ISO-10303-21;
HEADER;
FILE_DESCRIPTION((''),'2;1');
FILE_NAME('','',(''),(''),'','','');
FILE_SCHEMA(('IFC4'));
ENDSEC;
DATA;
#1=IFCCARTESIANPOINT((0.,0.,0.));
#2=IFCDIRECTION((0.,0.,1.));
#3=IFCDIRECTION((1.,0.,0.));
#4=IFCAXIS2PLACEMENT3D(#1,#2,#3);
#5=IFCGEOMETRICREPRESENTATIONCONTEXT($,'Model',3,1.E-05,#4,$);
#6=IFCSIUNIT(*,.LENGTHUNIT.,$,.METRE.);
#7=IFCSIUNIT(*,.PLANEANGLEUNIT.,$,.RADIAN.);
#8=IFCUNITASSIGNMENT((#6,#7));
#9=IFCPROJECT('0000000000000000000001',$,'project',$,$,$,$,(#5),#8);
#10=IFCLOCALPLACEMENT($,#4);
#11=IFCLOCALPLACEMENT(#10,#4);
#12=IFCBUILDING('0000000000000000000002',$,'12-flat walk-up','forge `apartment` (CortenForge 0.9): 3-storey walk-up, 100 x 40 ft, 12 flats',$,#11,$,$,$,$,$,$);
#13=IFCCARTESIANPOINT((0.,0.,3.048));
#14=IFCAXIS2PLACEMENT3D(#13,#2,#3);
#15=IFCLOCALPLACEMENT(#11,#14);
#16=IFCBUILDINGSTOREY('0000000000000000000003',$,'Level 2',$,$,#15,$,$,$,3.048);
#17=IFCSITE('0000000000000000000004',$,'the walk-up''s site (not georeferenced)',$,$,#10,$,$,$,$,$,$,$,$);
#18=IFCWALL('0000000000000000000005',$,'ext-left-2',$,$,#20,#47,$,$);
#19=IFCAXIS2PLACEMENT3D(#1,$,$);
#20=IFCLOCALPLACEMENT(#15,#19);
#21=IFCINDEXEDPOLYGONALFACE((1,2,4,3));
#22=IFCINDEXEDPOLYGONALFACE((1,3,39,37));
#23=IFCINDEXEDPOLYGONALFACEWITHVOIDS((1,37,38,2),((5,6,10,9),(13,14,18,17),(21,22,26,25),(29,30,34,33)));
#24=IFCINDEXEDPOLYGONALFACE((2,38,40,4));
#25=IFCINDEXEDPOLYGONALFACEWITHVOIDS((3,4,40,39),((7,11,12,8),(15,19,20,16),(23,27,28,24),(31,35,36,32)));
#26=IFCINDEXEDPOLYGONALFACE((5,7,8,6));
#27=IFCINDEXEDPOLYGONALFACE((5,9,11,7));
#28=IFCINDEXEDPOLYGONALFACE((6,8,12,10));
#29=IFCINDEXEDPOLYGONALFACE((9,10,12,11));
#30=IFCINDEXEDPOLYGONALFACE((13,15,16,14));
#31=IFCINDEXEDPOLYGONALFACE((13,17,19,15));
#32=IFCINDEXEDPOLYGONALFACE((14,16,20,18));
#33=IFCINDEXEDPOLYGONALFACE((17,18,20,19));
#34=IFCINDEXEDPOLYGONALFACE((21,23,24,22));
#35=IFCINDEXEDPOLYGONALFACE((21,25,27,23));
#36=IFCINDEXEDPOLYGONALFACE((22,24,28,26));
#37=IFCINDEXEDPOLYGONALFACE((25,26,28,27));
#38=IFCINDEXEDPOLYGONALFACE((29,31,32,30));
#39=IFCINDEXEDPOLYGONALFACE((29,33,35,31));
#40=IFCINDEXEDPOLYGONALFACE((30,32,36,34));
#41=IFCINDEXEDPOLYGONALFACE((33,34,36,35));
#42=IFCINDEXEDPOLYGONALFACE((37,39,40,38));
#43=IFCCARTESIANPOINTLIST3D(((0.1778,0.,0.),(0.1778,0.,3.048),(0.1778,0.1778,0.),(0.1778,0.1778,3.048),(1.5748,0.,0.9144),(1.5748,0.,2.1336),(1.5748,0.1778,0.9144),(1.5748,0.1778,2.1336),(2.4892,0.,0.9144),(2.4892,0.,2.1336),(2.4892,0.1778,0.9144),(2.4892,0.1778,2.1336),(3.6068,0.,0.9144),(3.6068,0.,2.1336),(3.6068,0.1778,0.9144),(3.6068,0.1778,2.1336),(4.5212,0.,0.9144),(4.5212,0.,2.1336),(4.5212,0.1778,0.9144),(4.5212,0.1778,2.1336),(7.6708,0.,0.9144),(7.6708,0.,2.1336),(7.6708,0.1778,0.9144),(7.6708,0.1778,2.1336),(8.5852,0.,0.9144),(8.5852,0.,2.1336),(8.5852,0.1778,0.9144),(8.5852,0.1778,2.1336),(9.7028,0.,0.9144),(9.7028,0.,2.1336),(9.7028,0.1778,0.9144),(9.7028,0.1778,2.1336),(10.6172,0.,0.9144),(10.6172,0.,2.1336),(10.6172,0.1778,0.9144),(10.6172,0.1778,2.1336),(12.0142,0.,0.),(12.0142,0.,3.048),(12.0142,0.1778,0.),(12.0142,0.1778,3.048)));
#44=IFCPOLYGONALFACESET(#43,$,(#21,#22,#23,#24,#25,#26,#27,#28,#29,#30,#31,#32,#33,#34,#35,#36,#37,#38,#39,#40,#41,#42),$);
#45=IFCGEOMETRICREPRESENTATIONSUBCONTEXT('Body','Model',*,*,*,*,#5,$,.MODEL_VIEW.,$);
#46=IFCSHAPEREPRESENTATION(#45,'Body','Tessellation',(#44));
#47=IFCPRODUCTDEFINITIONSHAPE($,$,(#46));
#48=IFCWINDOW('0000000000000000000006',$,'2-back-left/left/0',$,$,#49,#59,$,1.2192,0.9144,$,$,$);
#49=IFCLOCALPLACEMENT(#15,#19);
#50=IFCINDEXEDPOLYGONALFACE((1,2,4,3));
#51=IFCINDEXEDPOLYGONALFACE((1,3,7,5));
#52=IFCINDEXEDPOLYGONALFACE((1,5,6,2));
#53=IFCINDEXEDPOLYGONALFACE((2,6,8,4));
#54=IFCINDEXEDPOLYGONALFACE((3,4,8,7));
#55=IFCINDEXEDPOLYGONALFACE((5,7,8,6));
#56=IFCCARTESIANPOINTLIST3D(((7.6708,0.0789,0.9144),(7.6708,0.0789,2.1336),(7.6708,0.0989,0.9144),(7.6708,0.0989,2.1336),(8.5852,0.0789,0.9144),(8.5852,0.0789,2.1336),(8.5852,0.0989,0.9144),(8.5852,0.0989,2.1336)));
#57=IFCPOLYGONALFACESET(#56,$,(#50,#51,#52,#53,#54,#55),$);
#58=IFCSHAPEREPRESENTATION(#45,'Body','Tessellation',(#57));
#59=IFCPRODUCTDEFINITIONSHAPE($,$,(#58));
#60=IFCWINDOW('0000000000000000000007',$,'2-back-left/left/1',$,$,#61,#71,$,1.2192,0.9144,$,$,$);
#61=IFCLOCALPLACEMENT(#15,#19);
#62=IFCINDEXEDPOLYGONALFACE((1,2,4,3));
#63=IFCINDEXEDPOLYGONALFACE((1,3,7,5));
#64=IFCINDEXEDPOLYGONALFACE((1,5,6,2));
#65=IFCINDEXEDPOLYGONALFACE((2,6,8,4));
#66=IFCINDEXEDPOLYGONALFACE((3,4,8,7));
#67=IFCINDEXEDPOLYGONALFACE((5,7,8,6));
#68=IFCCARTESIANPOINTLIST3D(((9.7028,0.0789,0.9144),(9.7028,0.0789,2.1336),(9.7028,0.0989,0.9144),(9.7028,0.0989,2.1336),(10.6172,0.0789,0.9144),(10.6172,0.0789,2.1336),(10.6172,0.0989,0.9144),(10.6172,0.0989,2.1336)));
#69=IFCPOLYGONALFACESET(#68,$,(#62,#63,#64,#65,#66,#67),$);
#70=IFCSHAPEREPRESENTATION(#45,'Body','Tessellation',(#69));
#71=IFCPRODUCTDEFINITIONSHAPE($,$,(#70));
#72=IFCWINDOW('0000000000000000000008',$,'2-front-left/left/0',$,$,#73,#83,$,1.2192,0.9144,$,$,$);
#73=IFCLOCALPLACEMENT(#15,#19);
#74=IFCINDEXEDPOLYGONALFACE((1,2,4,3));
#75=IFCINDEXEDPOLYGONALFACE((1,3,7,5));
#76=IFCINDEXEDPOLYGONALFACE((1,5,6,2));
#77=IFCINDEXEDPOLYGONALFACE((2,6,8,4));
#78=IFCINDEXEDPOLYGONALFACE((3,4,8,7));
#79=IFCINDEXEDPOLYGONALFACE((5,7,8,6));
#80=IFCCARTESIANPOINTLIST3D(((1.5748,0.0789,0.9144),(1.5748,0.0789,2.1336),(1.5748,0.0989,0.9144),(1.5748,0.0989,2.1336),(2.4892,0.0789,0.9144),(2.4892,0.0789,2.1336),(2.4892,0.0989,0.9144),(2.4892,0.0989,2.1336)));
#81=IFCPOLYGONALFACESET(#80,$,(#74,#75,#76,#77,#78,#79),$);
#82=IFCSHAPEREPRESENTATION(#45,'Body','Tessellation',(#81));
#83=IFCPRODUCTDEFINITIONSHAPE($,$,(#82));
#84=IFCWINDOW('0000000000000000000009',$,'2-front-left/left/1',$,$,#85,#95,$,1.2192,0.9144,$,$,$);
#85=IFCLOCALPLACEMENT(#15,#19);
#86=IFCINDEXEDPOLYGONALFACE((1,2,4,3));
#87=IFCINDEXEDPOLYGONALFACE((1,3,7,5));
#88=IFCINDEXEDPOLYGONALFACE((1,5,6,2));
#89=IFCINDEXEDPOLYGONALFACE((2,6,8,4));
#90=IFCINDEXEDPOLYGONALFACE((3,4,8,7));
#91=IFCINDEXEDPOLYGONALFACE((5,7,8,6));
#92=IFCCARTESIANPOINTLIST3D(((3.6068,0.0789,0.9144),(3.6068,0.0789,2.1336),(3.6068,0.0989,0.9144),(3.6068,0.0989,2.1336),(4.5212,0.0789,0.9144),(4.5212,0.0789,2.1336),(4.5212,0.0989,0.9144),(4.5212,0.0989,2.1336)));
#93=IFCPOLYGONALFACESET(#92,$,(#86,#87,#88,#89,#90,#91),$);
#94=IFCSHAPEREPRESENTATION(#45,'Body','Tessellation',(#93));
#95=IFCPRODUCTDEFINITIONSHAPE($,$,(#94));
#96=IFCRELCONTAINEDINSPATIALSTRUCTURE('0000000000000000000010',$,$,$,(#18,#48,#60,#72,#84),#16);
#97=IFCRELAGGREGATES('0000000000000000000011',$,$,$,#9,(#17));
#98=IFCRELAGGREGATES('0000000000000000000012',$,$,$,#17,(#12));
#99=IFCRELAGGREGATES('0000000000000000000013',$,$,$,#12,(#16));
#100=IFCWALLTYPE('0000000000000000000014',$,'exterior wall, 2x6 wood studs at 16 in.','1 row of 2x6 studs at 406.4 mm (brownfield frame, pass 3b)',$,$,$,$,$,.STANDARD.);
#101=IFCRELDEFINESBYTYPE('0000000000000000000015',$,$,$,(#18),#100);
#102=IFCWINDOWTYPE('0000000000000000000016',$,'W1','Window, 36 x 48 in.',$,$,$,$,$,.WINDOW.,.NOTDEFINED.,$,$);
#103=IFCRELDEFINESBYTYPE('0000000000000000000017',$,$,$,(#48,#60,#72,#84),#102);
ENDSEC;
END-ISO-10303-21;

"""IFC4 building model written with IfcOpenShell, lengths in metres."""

from ifc_helpers import new_model, si_unit, frame, frame_2d, origin, origin_with_axes, place, context, subcontext, project, spatial, rectangle, extrude, type_object, element, fill, save


model = new_model("IFC4")

# Units and contexts
model_context = context("Model", 3, precision=1e-05, world=origin_with_axes())
body_context = subcontext(model_context, "Body", "Model", "MODEL_VIEW")
ifc_project = project(units=[si_unit("LENGTHUNIT", "METRE"), si_unit("PLANEANGLEUNIT", "RADIAN")], contexts=[model_context])

# Site, building, storey
site_placement = place(None, origin_with_axes())
site = spatial("IfcSite", under=ifc_project, at=site_placement, Name="the walk-up's site (not georeferenced)")
building_placement = place(site_placement, origin_with_axes())
building = spatial("IfcBuilding", under=site, at=building_placement, Name="12-flat walk-up", Description="forge `apartment` (CortenForge 0.9): 3-storey walk-up, 100 x 40 ft, 12 flats")
storey_placement = place(building_placement, frame((0.0, 0.0, 3.048), z_axis=(0.0, 0.0, 1.0), x_axis=(1.0, 0.0, 0.0)))
storey = spatial("IfcBuildingStorey", under=building, at=storey_placement, Name="Level 2", Elevation=3.048)

# Shared definitions
wall_type = type_object("IfcWallType", Name="exterior wall, 2x6 wood studs at 16 in.", Description="1 row of 2x6 studs at 406.4 mm (brownfield frame, pass 3b)", PredefinedType="STANDARD")
window_type = type_object("IfcWindowType", Name="W1", Description="Window, 36 x 48 in.", PartitioningType="NOTDEFINED", PredefinedType="WINDOW")

# Wall, openings, windows
wall_1_placement = place(storey_placement, frame((0.1778, 0.0, 0.0), z_axis=(0.0, 0.0, 1.0), x_axis=(1.0, 0.0, 0.0)))
wall_1 = element("IfcWall", 1, at=wall_1_placement, inside=storey, type_object=wall_type, Name="ext-left-2", context=body_context, shape_type="SweptSolid", body=[
    extrude(rectangle(XDim=11.8364, YDim=0.1778, at=frame_2d((5.9182, 0.0889))), origin(), (0.0, 0.0, 1.0), 3.048),
])
opening_1_placement = place(wall_1_placement, frame((7.493, 0.0, 0.9144), z_axis=(0.0, 0.0, 1.0), x_axis=(1.0, 0.0, 0.0)))
opening_1 = element("IfcOpeningElement", 2, at=opening_1_placement, cuts=wall_1, PredefinedType="OPENING", context=body_context, shape_type="SweptSolid", body=[
    extrude(rectangle(XDim=0.9144, YDim=0.1778, at=frame_2d((0.4572, 0.0889))), origin(), (0.0, 0.0, 1.0), 1.2192),
])
opening_2_placement = place(wall_1_placement, frame((9.525, 0.0, 0.9144), z_axis=(0.0, 0.0, 1.0), x_axis=(1.0, 0.0, 0.0)))
opening_2 = element("IfcOpeningElement", 3, at=opening_2_placement, cuts=wall_1, PredefinedType="OPENING", context=body_context, shape_type="SweptSolid", body=[
    extrude(rectangle(XDim=0.9144, YDim=0.1778, at=frame_2d((0.4572, 0.0889))), origin(), (0.0, 0.0, 1.0), 1.2192),
])
opening_3_placement = place(wall_1_placement, frame((1.397, 0.0, 0.9144), z_axis=(0.0, 0.0, 1.0), x_axis=(1.0, 0.0, 0.0)))
opening_3 = element("IfcOpeningElement", 4, at=opening_3_placement, cuts=wall_1, PredefinedType="OPENING", context=body_context, shape_type="SweptSolid", body=[
    extrude(rectangle(XDim=0.9144, YDim=0.1778, at=frame_2d((0.4572, 0.0889))), origin(), (0.0, 0.0, 1.0), 1.2192),
])
opening_4_placement = place(wall_1_placement, frame((3.429, 0.0, 0.9144), z_axis=(0.0, 0.0, 1.0), x_axis=(1.0, 0.0, 0.0)))
opening_4 = element("IfcOpeningElement", 5, at=opening_4_placement, cuts=wall_1, PredefinedType="OPENING", context=body_context, shape_type="SweptSolid", body=[
    extrude(rectangle(XDim=0.9144, YDim=0.1778, at=frame_2d((0.4572, 0.0889))), origin(), (0.0, 0.0, 1.0), 1.2192),
])
window_1_placement = place(opening_1_placement, frame((0.0, 0.0789, 0.0), z_axis=(0.0, 0.0, 1.0), x_axis=(1.0, 0.0, 0.0)))
window_1 = element("IfcWindow", 6, at=window_1_placement, inside=storey, type_object=window_type, Name="2-back-left/left/0", OverallHeight=1.2192, OverallWidth=0.9144, context=body_context, shape_type="SweptSolid", body=[
    extrude(rectangle(XDim=0.9144, YDim=0.02, at=frame_2d((0.4572, 0.01))), origin(), (0.0, 0.0, 1.0), 1.2192),
])
fill(opening_1, window_1)
window_2_placement = place(opening_2_placement, frame((0.0, 0.0789, 0.0), z_axis=(0.0, 0.0, 1.0), x_axis=(1.0, 0.0, 0.0)))
window_2 = element("IfcWindow", 7, at=window_2_placement, inside=storey, type_object=window_type, Name="2-back-left/left/1", OverallHeight=1.2192, OverallWidth=0.9144, context=body_context, shape_type="SweptSolid", body=[
    extrude(rectangle(XDim=0.9144, YDim=0.02, at=frame_2d((0.4572, 0.01))), origin(), (0.0, 0.0, 1.0), 1.2192),
])
fill(opening_2, window_2)
window_3_placement = place(opening_3_placement, frame((0.0, 0.0789, 0.0), z_axis=(0.0, 0.0, 1.0), x_axis=(1.0, 0.0, 0.0)))
window_3 = element("IfcWindow", 8, at=window_3_placement, inside=storey, type_object=window_type, Name="2-front-left/left/0", OverallHeight=1.2192, OverallWidth=0.9144, context=body_context, shape_type="SweptSolid", body=[
    extrude(rectangle(XDim=0.9144, YDim=0.02, at=frame_2d((0.4572, 0.01))), origin(), (0.0, 0.0, 1.0), 1.2192),
])
fill(opening_3, window_3)
window_4_placement = place(opening_4_placement, frame((0.0, 0.0789, 0.0), z_axis=(0.0, 0.0, 1.0), x_axis=(1.0, 0.0, 0.0)))
window_4 = element("IfcWindow", 9, at=window_4_placement, inside=storey, type_object=window_type, Name="2-front-left/left/1", OverallHeight=1.2192, OverallWidth=0.9144, context=body_context, shape_type="SweptSolid", body=[
    extrude(rectangle(XDim=0.9144, YDim=0.02, at=frame_2d((0.4572, 0.01))), origin(), (0.0, 0.0, 1.0), 1.2192),
])
fill(opening_4, window_4)

save(model, "model.ifc")
